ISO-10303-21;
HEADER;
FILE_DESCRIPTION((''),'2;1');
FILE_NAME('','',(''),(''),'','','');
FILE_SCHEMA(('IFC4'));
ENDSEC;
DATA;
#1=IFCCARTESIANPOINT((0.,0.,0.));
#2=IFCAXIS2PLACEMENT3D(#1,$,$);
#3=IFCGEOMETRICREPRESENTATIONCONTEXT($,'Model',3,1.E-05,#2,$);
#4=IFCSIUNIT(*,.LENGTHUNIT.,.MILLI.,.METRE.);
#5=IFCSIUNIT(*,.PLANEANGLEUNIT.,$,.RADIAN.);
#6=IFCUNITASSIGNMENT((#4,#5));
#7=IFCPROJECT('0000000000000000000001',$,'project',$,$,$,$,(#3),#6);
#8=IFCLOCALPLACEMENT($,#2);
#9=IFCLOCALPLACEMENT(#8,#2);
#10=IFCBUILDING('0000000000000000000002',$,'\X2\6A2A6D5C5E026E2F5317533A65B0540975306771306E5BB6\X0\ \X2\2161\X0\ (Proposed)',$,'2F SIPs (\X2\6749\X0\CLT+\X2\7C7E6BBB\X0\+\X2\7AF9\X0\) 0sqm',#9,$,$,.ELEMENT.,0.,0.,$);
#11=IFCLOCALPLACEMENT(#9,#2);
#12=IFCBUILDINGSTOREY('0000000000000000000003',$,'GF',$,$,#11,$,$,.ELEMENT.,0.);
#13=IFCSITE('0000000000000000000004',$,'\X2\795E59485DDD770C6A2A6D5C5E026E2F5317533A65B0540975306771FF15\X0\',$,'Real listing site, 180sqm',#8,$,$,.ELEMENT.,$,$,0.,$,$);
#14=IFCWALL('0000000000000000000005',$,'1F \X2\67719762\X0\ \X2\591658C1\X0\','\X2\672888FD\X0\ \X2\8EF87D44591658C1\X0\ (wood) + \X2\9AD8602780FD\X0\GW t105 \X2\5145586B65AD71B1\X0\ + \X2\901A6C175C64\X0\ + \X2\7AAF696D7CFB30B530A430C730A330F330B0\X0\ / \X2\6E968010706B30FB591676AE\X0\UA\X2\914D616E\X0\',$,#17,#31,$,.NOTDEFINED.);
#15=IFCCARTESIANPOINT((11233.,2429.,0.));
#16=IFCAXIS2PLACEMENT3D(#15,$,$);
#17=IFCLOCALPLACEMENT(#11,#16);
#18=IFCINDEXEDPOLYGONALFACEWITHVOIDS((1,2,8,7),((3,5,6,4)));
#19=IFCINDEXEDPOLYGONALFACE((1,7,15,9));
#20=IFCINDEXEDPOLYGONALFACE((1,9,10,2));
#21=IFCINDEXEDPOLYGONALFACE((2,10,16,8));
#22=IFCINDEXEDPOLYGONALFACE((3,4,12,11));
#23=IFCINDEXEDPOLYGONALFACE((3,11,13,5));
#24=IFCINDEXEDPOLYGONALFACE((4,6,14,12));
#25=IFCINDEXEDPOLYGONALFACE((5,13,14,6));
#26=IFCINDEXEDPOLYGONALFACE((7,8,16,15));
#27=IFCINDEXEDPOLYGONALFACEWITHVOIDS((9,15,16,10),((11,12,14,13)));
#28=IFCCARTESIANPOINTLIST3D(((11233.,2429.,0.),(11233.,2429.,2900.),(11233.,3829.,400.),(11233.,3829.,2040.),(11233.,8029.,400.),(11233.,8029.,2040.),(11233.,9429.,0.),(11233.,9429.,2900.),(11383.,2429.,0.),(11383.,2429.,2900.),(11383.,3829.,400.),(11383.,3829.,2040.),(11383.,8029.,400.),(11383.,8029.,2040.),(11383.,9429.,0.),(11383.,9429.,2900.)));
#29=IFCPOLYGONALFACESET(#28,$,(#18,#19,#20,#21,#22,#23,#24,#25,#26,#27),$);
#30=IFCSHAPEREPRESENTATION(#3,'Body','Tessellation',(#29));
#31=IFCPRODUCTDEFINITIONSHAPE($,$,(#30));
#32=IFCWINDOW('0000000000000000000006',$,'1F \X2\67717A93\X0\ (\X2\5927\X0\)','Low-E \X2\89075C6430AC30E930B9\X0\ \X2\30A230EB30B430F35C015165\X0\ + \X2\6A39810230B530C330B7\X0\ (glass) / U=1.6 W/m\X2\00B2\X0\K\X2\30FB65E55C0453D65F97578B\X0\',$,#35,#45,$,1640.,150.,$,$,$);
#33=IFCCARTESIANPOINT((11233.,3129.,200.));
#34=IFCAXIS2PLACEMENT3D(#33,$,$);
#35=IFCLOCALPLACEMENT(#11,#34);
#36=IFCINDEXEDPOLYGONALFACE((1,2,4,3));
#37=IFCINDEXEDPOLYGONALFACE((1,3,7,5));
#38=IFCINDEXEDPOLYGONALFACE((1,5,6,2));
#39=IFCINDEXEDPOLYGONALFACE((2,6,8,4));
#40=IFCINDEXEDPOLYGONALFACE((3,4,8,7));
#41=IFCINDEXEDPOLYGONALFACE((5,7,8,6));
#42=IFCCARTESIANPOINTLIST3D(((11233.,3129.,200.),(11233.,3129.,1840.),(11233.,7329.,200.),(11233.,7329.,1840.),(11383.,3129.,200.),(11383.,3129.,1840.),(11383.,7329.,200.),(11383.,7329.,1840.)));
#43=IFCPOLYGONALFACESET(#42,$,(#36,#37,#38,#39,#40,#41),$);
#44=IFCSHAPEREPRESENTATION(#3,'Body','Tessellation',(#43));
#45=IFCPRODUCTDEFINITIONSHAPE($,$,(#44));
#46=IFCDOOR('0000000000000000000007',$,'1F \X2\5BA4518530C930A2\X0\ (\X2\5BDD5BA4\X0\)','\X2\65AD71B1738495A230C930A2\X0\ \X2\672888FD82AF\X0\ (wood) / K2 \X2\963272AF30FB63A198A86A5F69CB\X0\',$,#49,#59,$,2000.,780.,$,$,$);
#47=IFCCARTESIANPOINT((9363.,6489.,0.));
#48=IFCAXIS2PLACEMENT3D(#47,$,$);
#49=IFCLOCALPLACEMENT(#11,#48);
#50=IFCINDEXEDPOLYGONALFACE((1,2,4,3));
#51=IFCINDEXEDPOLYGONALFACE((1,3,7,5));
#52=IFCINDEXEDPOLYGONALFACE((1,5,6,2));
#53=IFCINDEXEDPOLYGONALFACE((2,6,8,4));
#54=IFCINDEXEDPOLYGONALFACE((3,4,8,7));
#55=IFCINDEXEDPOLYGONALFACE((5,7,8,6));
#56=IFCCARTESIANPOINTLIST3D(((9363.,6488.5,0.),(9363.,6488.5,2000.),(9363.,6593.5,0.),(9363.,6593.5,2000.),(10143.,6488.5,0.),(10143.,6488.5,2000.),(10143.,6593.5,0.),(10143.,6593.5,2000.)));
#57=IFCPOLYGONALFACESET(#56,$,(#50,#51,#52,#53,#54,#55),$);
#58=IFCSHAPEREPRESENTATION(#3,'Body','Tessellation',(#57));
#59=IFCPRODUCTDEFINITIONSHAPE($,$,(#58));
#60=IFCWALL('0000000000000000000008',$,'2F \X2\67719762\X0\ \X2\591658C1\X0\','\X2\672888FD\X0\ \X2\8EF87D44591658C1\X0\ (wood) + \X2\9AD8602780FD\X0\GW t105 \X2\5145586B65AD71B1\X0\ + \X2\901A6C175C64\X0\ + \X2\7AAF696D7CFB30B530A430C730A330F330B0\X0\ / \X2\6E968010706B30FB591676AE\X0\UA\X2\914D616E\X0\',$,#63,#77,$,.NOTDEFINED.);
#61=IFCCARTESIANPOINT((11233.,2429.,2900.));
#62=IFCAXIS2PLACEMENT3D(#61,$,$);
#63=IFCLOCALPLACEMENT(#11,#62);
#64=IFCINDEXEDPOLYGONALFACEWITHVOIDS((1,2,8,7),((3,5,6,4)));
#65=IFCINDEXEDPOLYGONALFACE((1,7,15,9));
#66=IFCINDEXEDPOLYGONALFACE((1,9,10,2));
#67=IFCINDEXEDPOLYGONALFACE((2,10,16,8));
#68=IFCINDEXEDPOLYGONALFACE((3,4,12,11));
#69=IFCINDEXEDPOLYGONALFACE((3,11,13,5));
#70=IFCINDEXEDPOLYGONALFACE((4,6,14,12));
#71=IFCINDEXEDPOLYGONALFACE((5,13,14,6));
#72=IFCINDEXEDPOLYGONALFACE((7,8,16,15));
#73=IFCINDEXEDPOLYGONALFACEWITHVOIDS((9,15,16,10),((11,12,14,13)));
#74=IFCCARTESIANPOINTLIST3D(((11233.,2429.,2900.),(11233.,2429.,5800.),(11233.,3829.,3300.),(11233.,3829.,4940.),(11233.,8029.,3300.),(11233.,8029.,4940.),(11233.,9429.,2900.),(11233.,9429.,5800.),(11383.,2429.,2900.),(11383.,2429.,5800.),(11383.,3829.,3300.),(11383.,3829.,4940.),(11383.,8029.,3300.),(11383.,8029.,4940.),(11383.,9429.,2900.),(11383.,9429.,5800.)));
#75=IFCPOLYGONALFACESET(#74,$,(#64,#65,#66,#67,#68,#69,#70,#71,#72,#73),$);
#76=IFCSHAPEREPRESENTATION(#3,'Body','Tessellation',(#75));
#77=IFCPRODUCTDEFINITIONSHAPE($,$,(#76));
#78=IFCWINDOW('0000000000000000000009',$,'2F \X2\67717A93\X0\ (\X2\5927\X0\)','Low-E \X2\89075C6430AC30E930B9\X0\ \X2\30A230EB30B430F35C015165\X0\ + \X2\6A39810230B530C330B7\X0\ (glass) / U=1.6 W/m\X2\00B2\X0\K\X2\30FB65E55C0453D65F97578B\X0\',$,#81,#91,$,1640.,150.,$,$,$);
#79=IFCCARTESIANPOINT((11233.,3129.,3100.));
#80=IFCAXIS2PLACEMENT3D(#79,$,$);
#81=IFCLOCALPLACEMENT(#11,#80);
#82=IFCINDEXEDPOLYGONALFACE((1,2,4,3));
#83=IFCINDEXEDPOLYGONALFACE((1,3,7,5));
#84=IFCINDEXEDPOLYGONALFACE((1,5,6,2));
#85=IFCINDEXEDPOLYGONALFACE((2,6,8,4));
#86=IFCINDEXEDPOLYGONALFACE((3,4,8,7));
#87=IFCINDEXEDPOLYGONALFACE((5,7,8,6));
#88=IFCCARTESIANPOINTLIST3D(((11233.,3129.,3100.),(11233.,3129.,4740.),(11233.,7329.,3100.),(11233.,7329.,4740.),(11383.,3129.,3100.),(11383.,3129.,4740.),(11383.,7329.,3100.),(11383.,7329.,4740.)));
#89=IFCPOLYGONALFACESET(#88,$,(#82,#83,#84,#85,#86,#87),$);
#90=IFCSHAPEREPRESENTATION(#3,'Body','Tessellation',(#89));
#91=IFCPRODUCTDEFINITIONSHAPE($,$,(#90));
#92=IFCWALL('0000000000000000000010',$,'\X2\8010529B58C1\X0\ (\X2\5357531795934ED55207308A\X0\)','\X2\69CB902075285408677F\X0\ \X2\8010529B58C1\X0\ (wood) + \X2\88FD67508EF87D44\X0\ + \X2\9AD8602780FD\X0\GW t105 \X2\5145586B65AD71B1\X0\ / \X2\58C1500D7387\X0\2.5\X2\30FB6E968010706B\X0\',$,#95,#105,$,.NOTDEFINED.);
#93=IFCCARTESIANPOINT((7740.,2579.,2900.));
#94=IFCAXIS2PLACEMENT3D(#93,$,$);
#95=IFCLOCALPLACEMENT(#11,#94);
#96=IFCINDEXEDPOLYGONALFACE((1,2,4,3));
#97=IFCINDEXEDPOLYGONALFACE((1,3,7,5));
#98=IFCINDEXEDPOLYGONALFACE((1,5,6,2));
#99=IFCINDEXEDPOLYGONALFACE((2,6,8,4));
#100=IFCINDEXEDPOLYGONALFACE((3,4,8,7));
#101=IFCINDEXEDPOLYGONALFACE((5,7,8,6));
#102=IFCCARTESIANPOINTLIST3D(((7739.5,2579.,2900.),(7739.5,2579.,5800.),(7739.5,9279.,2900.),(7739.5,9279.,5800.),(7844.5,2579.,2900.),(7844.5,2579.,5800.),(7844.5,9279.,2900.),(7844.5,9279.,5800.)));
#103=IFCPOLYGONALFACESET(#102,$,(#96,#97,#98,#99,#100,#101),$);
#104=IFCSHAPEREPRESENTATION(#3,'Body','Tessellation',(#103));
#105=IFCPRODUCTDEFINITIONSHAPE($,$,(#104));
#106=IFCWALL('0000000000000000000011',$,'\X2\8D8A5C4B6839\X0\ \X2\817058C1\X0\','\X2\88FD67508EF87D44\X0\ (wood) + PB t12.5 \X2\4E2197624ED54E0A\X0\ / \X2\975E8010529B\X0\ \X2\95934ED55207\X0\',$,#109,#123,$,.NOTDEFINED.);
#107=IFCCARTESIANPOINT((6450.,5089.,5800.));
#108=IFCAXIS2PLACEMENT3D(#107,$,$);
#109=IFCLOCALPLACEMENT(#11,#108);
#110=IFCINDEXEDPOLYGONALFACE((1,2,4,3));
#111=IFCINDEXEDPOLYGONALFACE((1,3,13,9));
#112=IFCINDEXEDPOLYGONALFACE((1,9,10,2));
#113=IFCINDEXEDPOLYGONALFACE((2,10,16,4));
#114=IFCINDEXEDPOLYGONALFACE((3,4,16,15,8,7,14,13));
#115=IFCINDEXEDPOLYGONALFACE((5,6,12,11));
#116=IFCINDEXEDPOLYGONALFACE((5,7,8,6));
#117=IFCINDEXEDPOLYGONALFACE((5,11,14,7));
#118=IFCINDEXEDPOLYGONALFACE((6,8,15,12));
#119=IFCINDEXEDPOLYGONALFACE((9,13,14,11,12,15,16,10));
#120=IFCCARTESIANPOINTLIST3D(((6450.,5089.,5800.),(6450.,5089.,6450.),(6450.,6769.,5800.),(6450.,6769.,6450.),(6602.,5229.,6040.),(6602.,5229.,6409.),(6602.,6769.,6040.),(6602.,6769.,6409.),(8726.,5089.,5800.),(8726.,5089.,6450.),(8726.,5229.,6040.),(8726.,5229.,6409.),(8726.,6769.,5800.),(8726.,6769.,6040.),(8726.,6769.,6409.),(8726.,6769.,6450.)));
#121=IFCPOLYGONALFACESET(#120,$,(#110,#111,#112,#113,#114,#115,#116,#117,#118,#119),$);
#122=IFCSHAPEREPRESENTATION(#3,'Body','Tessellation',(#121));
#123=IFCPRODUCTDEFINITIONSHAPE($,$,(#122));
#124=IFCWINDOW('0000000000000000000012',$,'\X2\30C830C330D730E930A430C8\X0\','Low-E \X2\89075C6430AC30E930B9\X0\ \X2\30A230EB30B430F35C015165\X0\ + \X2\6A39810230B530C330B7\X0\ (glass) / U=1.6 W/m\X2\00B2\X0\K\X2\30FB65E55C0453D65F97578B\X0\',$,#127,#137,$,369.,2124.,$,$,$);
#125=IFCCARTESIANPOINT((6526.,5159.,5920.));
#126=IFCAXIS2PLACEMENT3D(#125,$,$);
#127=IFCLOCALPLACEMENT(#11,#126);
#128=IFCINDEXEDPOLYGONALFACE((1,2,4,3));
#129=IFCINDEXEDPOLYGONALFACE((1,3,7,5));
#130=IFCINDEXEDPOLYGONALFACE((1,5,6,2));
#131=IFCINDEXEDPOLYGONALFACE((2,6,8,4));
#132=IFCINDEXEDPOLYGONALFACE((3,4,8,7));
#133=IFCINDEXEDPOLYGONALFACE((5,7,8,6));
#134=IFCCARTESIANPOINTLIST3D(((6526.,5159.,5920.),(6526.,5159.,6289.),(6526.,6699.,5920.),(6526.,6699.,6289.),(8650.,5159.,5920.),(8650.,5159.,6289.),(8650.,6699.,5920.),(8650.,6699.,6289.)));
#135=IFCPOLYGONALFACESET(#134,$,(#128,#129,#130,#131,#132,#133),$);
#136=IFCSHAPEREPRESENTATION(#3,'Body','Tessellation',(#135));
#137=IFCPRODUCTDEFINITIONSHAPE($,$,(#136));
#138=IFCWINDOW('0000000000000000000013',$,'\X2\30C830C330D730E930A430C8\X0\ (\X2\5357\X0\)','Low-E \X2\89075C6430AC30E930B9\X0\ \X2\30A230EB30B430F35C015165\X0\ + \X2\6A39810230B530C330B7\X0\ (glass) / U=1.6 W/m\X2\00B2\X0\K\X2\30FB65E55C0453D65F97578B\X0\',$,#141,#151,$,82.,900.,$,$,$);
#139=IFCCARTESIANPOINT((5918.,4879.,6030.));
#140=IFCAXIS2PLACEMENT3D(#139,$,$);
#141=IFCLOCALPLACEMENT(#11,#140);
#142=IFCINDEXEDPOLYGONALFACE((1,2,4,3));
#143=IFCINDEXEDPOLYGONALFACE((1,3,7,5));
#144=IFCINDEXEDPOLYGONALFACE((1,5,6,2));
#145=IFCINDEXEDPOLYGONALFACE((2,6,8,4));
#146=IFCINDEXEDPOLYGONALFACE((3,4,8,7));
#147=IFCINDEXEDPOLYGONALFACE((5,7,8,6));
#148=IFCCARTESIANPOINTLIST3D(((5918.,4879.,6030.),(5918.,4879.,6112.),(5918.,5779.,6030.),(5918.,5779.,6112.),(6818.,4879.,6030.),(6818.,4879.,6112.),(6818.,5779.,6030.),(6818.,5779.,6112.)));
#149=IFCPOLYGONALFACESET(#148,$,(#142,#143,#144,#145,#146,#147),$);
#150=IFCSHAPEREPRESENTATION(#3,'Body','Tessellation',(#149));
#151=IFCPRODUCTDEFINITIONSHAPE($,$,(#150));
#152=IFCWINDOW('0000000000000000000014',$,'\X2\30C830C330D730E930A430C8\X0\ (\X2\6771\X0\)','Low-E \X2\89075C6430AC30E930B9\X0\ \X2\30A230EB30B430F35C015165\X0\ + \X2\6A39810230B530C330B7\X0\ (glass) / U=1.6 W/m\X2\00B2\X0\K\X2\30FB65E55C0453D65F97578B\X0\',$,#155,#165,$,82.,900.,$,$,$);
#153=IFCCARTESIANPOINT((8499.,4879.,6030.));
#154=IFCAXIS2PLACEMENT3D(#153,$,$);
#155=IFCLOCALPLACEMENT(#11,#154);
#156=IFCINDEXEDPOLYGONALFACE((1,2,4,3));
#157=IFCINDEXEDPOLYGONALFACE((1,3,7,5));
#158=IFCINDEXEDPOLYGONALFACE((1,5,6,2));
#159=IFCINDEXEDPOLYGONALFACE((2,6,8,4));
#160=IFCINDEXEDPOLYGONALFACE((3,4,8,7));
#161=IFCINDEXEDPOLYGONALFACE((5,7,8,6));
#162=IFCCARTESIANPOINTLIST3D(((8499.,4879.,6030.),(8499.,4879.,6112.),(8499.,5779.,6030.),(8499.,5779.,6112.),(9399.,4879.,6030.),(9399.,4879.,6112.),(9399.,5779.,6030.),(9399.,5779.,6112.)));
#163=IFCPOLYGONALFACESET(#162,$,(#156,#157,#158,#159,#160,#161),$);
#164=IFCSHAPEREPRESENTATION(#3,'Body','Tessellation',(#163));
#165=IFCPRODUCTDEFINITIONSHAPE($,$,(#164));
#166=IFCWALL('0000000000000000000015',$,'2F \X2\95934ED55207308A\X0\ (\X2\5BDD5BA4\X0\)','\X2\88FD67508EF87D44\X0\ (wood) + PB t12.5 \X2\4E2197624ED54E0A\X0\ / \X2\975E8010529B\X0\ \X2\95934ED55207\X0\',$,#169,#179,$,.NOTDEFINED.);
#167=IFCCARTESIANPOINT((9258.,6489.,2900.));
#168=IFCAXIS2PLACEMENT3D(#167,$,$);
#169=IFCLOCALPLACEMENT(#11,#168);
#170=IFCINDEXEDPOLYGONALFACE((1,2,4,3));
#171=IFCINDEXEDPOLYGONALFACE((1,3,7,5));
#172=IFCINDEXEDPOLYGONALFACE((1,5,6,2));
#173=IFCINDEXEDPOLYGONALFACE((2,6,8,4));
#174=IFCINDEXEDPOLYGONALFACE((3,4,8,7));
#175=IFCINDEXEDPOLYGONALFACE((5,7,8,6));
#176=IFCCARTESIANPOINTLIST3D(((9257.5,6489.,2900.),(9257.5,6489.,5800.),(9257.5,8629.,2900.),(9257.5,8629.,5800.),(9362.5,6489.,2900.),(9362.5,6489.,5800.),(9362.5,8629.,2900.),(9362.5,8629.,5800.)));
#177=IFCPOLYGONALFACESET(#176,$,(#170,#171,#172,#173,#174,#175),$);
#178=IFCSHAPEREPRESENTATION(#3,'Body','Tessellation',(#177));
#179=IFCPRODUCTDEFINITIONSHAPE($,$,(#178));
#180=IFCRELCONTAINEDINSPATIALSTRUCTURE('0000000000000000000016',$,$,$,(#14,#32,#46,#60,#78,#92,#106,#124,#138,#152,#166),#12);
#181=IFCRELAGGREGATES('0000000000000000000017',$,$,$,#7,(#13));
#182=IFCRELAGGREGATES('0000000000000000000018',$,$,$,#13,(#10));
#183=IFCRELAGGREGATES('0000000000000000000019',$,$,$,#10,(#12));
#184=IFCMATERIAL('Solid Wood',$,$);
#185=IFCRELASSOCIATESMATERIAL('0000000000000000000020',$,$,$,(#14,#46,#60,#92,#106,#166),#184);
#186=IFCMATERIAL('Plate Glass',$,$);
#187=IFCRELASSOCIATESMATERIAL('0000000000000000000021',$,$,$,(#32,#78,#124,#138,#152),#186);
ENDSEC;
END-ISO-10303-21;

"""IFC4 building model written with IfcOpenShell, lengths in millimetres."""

from ifc_helpers import new_model, si_unit, frame, frame_2d, origin, place, context, project, spatial, rectangle, extrude, material, element, fill, save


model = new_model("IFC4")

# Units and contexts
model_context = context("Model", 3, precision=1e-05, world=origin())
ifc_project = project(units=[si_unit("LENGTHUNIT", "METRE", prefix="MILLI"), si_unit("PLANEANGLEUNIT", "RADIAN")], contexts=[model_context])

# Site, building, storey
site_placement = place(None, origin())
site = spatial("IfcSite", under=ifc_project, at=site_placement, Name="神奈川県横浜市港北区新吉田東５", ObjectType="Real listing site, 180sqm", CompositionType="ELEMENT", RefElevation=0.0)
building_placement = place(site_placement, origin())
building = spatial("IfcBuilding", under=site, at=building_placement, Name="横浜市港北区新吉田東の家 Ⅱ (Proposed)", ObjectType="2F SIPs (杉CLT+籾殻+竹) 0sqm", CompositionType="ELEMENT", ElevationOfRefHeight=0.0, ElevationOfTerrain=0.0)
storey_placement = place(building_placement, origin())
storey = spatial("IfcBuildingStorey", under=building, at=storey_placement, Name="GF", CompositionType="ELEMENT", Elevation=0.0)

# Wall, opening, window
ifc_material_1 = material(Name="Solid Wood")
wall_1_placement = place(storey_placement, frame((11233.0, 2429.0, 0.0)))
wall_1 = element("IfcWall", 1, at=wall_1_placement, inside=storey, material=ifc_material_1, Name="1F 東面 外壁", Description="木製 軸組外壁 (wood) + 高性能GW t105 充填断熱 + 通気層 + 窯業系サイディング / 準耐火・外皮UA配慮", PredefinedType="NOTDEFINED", context=model_context, shape_type="SweptSolid", body=[
    extrude(rectangle(XDim=150.0, YDim=7000.0, at=frame_2d((75.0, 3500.0))), frame((11233.0, 2429.0, 0.0)), (0.0, 0.0, 1.0), 2900.0),
])
opening_1_placement = place(storey_placement, frame((11233.0, 3129.0, 200.0)))
opening_1 = element("IfcOpeningElement", 2, at=opening_1_placement, cuts=wall_1, PredefinedType="NOTDEFINED", context=model_context, shape_type="SweptSolid", body=[
    extrude(rectangle(XDim=150.0, YDim=4200.0, at=frame_2d((75.0, 2100.0))), frame((11233.0, 3129.0, 200.0)), (0.0, 0.0, 1.0), 1640.0),
])
ifc_material_2 = material(Name="Plate Glass")
window_1_placement = place(storey_placement, frame((11233.0, 3129.0, 200.0)))
window_1 = element("IfcWindow", 3, at=window_1_placement, inside=storey, material=ifc_material_2, Name="1F 東窓 (大)", Description="Low-E 複層ガラス アルゴン封入 + 樹脂サッシ (glass) / U=1.6 W/m²K・日射取得型", OverallHeight=1640.0, OverallWidth=150.0, context=model_context, shape_type="SweptSolid", body=[
    extrude(rectangle(XDim=150.0, YDim=4200.0, at=frame_2d((75.0, 2100.0))), frame((11233.0, 3129.0, 200.0)), (0.0, 0.0, 1.0), 1640.0),
])
fill(opening_1, window_1)

# Door
door_1_placement = place(storey_placement, frame((9363.0, 6489.0, 0.0)))
element("IfcDoor", 4, at=door_1_placement, inside=storey, material=ifc_material_1, Name="1F 室内ドア (寝室)", Description="断熱玄関ドア 木製芯 (wood) / K2 防犯・採風機構", OverallHeight=2000.0, OverallWidth=780.0, context=model_context, shape_type="SweptSolid", body=[
    extrude(rectangle(XDim=780.0, YDim=105.0, at=frame_2d((390.0, 52.0))), frame((9363.0, 6489.0, 0.0)), (0.0, 0.0, 1.0), 2000.0),
])

# Wall, opening, window
wall_2_placement = place(storey_placement, frame((11233.0, 2429.0, 2900.0)))
wall_2 = element("IfcWall", 5, at=wall_2_placement, inside=storey, material=ifc_material_1, Name="2F 東面 外壁", Description="木製 軸組外壁 (wood) + 高性能GW t105 充填断熱 + 通気層 + 窯業系サイディング / 準耐火・外皮UA配慮", PredefinedType="NOTDEFINED", context=model_context, shape_type="SweptSolid", body=[
    extrude(rectangle(XDim=150.0, YDim=7000.0, at=frame_2d((75.0, 3500.0))), frame((11233.0, 2429.0, 2900.0)), (0.0, 0.0, 1.0), 2900.0),
])
opening_2_placement = place(storey_placement, frame((11233.0, 3129.0, 3100.0)))
opening_2 = element("IfcOpeningElement", 6, at=opening_2_placement, cuts=wall_2, PredefinedType="NOTDEFINED", context=model_context, shape_type="SweptSolid", body=[
    extrude(rectangle(XDim=150.0, YDim=4200.0, at=frame_2d((75.0, 2100.0))), frame((11233.0, 3129.0, 3100.0)), (0.0, 0.0, 1.0), 1640.0),
])
window_2_placement = place(storey_placement, frame((11233.0, 3129.0, 3100.0)))
window_2 = element("IfcWindow", 7, at=window_2_placement, inside=storey, material=ifc_material_2, Name="2F 東窓 (大)", Description="Low-E 複層ガラス アルゴン封入 + 樹脂サッシ (glass) / U=1.6 W/m²K・日射取得型", OverallHeight=1640.0, OverallWidth=150.0, context=model_context, shape_type="SweptSolid", body=[
    extrude(rectangle(XDim=150.0, YDim=4200.0, at=frame_2d((75.0, 2100.0))), frame((11233.0, 3129.0, 3100.0)), (0.0, 0.0, 1.0), 1640.0),
])
fill(opening_2, window_2)

# Wall
wall_3_placement = place(storey_placement, frame((7740.0, 2579.0, 2900.0)))
element("IfcWall", 8, at=wall_3_placement, inside=storey, material=ifc_material_1, Name="耐力壁 (南北間仕切り)", Description="構造用合板 耐力壁 (wood) + 製材軸組 + 高性能GW t105 充填断熱 / 壁倍率2.5・準耐火", PredefinedType="NOTDEFINED", context=model_context, shape_type="SweptSolid", body=[
    extrude(rectangle(XDim=105.0, YDim=6700.0, at=frame_2d((52.0, 3350.0))), frame((7740.0, 2579.0, 2900.0)), (0.0, 0.0, 1.0), 2900.0),
])

# Wall, openings, windows
wall_4_placement = place(storey_placement, frame((6450.0, 5089.0, 5800.0)))
wall_4 = element("IfcWall", 9, at=wall_4_placement, inside=storey, material=ifc_material_1, Name="越屋根 腰壁", Description="製材軸組 (wood) + PB t12.5 両面仕上 / 非耐力 間仕切", PredefinedType="NOTDEFINED", context=model_context, shape_type="SweptSolid", body=[
    extrude(rectangle(XDim=2276.0, YDim=1680.0, at=frame_2d((1138.0, 840.0))), frame((6450.0, 5089.0, 5800.0)), (0.0, 0.0, 1.0), 650.0),
])
opening_3_placement = place(storey_placement, frame((6526.0, 5159.0, 5920.0)))
opening_3 = element("IfcOpeningElement", 10, at=opening_3_placement, cuts=wall_4, PredefinedType="NOTDEFINED", context=model_context, shape_type="SweptSolid", body=[
    extrude(rectangle(XDim=2124.0, YDim=1540.0, at=frame_2d((1062.0, 770.0))), frame((6526.0, 5159.0, 5920.0)), (0.0, 0.0, 1.0), 369.0),
])
opening_4_placement = place(storey_placement, frame((5918.0, 4879.0, 6030.0)))
opening_4 = element("IfcOpeningElement", 11, at=opening_4_placement, cuts=wall_4, PredefinedType="NOTDEFINED", context=model_context, shape_type="SweptSolid", body=[
    extrude(rectangle(XDim=900.0, YDim=900.0, at=frame_2d((450.0, 450.0))), frame((5918.0, 4879.0, 6030.0)), (0.0, 0.0, 1.0), 82.0),
])
opening_5_placement = place(storey_placement, frame((8499.0, 4879.0, 6030.0)))
opening_5 = element("IfcOpeningElement", 12, at=opening_5_placement, cuts=wall_4, PredefinedType="NOTDEFINED", context=model_context, shape_type="SweptSolid", body=[
    extrude(rectangle(XDim=900.0, YDim=900.0, at=frame_2d((450.0, 450.0))), frame((8499.0, 4879.0, 6030.0)), (0.0, 0.0, 1.0), 82.0),
])
window_3_placement = place(storey_placement, frame((6526.0, 5159.0, 5920.0)))
window_3 = element("IfcWindow", 13, at=window_3_placement, inside=storey, material=ifc_material_2, Name="トップライト", Description="Low-E 複層ガラス アルゴン封入 + 樹脂サッシ (glass) / U=1.6 W/m²K・日射取得型", OverallHeight=369.0, OverallWidth=2124.0, context=model_context, shape_type="SweptSolid", body=[
    extrude(rectangle(XDim=2124.0, YDim=1540.0, at=frame_2d((1062.0, 770.0))), frame((6526.0, 5159.0, 5920.0)), (0.0, 0.0, 1.0), 369.0),
])
fill(opening_3, window_3)
window_4_placement = place(storey_placement, frame((5918.0, 4879.0, 6030.0)))
window_4 = element("IfcWindow", 14, at=window_4_placement, inside=storey, material=ifc_material_2, Name="トップライト (南)", Description="Low-E 複層ガラス アルゴン封入 + 樹脂サッシ (glass) / U=1.6 W/m²K・日射取得型", OverallHeight=82.0, OverallWidth=900.0, context=model_context, shape_type="SweptSolid", body=[
    extrude(rectangle(XDim=900.0, YDim=900.0, at=frame_2d((450.0, 450.0))), frame((5918.0, 4879.0, 6030.0)), (0.0, 0.0, 1.0), 82.0),
])
fill(opening_4, window_4)
window_5_placement = place(storey_placement, frame((8499.0, 4879.0, 6030.0)))
window_5 = element("IfcWindow", 15, at=window_5_placement, inside=storey, material=ifc_material_2, Name="トップライト (東)", Description="Low-E 複層ガラス アルゴン封入 + 樹脂サッシ (glass) / U=1.6 W/m²K・日射取得型", OverallHeight=82.0, OverallWidth=900.0, context=model_context, shape_type="SweptSolid", body=[
    extrude(rectangle(XDim=900.0, YDim=900.0, at=frame_2d((450.0, 450.0))), frame((8499.0, 4879.0, 6030.0)), (0.0, 0.0, 1.0), 82.0),
])
fill(opening_5, window_5)

# Wall
wall_5_placement = place(storey_placement, frame((9258.0, 6489.0, 2900.0)))
element("IfcWall", 16, at=wall_5_placement, inside=storey, material=ifc_material_1, Name="2F 間仕切り (寝室)", Description="製材軸組 (wood) + PB t12.5 両面仕上 / 非耐力 間仕切", PredefinedType="NOTDEFINED", context=model_context, shape_type="SweptSolid", body=[
    extrude(rectangle(XDim=105.0, YDim=2140.0, at=frame_2d((52.0, 1070.0))), frame((9258.0, 6489.0, 2900.0)), (0.0, 0.0, 1.0), 2900.0),
])

save(model, "model.ifc")
